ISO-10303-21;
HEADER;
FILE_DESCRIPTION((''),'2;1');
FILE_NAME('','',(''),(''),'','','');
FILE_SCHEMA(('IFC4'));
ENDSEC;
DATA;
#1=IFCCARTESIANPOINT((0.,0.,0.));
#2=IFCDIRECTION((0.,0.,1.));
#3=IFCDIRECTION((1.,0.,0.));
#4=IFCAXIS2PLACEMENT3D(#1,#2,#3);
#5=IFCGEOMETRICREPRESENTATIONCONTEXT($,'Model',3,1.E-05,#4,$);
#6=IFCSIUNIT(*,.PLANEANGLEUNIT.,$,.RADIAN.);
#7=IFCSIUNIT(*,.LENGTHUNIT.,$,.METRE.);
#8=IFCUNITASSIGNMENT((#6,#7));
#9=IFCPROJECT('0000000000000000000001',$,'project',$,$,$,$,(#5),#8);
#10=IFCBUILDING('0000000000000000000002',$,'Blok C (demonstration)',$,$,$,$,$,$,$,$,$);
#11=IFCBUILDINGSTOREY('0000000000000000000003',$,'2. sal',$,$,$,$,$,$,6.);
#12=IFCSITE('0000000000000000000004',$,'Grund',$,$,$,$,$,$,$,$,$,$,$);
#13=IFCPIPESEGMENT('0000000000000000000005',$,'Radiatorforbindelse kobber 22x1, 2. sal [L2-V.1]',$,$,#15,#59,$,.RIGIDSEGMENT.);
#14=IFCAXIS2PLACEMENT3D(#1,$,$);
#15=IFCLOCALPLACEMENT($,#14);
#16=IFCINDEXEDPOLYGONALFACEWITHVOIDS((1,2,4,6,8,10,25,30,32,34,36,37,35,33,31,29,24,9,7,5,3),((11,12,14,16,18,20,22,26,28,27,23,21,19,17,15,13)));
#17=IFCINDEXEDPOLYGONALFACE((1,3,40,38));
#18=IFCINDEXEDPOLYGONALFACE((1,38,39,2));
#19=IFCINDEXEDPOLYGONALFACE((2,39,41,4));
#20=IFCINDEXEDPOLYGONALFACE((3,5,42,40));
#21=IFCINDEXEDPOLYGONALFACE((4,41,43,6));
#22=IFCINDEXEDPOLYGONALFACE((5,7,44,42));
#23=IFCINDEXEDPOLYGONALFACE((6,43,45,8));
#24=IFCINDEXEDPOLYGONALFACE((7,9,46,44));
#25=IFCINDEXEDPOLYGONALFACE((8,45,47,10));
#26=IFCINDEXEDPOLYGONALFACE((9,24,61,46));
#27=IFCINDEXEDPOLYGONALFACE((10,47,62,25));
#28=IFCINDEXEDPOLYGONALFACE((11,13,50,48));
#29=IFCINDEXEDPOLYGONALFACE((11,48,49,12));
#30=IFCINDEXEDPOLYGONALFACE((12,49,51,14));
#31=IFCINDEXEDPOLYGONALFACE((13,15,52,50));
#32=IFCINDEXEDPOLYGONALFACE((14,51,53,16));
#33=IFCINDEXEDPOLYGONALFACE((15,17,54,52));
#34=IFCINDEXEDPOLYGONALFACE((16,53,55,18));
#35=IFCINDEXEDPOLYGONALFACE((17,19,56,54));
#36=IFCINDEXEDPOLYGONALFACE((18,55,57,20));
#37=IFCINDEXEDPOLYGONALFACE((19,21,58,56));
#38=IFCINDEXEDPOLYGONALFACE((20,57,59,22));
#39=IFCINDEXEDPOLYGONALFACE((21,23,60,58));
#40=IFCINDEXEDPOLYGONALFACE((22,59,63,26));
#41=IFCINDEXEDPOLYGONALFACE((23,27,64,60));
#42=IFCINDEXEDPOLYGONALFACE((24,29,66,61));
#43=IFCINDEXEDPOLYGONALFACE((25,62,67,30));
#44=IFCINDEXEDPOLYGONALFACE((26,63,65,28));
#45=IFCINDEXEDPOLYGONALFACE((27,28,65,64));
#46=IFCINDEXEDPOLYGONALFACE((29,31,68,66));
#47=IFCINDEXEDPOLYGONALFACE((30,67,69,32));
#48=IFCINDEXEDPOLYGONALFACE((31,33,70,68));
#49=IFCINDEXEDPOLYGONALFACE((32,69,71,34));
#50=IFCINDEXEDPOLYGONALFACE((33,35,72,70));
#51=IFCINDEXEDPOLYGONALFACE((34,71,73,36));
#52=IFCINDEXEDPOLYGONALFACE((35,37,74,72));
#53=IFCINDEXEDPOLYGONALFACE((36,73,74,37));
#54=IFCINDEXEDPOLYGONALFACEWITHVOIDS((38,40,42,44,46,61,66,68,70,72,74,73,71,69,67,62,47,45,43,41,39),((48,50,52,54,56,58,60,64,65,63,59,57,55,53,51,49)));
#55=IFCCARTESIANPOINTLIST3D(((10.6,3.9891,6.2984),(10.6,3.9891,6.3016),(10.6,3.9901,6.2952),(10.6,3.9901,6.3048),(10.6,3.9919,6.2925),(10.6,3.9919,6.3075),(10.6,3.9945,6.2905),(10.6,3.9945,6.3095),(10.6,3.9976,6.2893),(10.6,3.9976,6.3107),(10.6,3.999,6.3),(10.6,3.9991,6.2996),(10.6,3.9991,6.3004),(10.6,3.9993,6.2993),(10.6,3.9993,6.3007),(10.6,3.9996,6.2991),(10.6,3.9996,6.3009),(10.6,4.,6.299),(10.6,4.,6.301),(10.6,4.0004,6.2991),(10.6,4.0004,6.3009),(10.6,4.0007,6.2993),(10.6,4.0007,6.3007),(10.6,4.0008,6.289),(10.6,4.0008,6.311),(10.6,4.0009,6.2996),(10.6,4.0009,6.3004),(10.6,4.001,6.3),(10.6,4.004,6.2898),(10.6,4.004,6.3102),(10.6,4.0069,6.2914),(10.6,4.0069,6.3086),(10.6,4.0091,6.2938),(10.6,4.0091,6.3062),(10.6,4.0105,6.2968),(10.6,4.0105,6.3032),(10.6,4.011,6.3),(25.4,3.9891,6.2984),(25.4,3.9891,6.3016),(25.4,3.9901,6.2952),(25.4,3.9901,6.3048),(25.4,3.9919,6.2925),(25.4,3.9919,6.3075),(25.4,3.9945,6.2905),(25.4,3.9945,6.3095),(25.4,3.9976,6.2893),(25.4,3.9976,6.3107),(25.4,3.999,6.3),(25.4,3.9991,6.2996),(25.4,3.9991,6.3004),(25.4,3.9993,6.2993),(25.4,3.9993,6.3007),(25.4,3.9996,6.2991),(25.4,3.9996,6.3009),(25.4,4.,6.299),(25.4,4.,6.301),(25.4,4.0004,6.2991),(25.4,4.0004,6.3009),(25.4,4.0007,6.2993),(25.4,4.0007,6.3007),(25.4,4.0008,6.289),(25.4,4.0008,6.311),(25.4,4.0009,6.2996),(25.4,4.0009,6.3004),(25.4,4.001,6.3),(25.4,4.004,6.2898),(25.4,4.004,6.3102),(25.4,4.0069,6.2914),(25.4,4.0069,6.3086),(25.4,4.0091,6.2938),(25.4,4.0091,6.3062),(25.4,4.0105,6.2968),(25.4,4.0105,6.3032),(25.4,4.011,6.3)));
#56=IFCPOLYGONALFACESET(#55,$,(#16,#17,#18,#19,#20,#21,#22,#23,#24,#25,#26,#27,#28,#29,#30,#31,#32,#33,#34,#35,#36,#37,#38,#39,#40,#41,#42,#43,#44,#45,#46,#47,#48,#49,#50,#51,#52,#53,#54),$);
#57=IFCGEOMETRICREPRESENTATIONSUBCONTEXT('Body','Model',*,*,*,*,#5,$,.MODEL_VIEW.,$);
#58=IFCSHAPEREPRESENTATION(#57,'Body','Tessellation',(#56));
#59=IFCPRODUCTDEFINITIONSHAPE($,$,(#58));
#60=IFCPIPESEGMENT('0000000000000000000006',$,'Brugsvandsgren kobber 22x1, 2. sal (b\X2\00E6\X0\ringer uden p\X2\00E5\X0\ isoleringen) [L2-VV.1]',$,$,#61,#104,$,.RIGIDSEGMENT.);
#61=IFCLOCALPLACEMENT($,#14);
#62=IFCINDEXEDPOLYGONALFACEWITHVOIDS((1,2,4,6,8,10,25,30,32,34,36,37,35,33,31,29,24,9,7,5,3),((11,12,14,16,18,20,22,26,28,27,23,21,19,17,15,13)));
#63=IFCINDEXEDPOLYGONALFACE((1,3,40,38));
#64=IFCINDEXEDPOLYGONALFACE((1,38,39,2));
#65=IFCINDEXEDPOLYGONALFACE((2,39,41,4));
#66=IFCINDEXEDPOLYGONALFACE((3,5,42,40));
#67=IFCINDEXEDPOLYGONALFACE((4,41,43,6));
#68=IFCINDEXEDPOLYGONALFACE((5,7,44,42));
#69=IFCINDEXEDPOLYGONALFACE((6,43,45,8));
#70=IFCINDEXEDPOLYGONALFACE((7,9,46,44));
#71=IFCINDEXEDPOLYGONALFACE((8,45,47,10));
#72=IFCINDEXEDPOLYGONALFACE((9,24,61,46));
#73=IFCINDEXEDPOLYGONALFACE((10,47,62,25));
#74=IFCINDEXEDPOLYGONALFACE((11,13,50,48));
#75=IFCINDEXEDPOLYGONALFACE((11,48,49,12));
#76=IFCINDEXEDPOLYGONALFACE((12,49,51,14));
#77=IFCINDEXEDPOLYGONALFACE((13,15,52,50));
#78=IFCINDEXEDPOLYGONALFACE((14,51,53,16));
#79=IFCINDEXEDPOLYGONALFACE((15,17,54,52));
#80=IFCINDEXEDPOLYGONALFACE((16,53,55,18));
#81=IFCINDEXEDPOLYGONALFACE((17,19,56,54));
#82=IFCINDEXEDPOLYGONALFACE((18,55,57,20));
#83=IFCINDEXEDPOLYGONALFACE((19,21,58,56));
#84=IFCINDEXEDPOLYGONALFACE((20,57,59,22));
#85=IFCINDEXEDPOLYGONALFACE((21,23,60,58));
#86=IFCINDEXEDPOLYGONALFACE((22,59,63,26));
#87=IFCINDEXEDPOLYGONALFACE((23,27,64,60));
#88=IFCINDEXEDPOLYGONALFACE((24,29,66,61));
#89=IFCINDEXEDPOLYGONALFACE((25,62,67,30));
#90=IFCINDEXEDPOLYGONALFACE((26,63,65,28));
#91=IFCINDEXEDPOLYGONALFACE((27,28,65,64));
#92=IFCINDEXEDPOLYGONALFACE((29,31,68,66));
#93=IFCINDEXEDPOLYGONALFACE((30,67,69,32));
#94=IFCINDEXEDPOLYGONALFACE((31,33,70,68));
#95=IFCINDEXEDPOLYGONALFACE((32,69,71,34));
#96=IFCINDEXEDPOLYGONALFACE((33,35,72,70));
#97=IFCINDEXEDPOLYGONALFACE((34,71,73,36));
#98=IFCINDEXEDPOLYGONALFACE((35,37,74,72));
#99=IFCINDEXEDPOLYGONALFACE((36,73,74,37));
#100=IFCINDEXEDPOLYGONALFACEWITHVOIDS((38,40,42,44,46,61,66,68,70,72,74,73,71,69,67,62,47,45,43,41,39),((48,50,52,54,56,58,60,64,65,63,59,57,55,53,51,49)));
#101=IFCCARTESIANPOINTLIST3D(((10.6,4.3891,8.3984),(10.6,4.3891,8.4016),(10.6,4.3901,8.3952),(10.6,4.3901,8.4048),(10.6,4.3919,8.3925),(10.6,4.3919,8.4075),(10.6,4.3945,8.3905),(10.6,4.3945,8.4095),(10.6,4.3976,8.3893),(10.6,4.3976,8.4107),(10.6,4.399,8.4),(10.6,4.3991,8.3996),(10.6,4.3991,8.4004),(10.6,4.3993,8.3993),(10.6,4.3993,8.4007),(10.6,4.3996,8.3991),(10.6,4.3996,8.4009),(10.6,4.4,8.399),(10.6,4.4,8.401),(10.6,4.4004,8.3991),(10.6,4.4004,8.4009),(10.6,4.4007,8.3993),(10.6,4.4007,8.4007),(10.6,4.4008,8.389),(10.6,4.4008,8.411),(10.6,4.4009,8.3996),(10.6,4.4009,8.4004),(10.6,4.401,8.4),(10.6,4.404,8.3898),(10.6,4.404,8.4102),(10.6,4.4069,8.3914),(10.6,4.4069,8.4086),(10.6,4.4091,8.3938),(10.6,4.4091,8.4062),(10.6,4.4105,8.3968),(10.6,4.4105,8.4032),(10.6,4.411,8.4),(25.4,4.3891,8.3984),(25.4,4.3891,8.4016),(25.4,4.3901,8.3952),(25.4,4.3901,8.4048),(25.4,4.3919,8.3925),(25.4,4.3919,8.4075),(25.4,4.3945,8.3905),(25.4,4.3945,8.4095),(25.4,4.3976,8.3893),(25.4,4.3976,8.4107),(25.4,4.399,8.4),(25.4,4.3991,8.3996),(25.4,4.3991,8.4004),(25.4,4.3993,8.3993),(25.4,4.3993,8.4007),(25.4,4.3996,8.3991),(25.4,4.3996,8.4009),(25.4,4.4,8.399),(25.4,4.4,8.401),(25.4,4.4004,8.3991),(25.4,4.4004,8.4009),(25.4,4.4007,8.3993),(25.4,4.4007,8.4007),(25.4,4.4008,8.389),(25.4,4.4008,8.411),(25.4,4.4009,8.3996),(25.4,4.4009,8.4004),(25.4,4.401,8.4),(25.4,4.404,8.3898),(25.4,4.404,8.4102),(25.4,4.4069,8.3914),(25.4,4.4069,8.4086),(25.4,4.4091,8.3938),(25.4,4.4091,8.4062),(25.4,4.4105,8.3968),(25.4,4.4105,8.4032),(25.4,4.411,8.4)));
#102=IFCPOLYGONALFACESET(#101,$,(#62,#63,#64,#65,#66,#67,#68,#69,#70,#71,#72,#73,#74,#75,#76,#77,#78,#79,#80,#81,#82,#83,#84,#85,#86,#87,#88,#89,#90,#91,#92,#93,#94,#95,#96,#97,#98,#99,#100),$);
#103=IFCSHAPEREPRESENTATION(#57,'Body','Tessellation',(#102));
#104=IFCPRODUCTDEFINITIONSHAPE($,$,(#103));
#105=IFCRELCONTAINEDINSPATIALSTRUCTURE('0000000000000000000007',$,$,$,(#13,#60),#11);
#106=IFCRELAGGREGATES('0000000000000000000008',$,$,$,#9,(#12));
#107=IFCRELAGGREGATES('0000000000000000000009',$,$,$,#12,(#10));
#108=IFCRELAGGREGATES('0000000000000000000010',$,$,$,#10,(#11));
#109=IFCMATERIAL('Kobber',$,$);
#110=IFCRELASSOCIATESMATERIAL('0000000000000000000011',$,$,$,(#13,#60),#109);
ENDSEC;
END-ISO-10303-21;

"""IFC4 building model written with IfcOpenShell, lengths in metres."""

from ifc_helpers import new_model, si_unit, frame, origin_with_axes, place, context, subcontext, project, spatial, hollow_circle, extrude, material, element, save


model = new_model("IFC4")

# Units and contexts
model_context = context("Model", 3, precision=1e-05, world=origin_with_axes())
body_context = subcontext(model_context, "Body", "Model", "MODEL_VIEW")
ifc_project = project(units=[si_unit("PLANEANGLEUNIT", "RADIAN"), si_unit("LENGTHUNIT", "METRE")], contexts=[model_context])

# Site, building, storey
site = spatial("IfcSite", under=ifc_project, Name="Grund")
building = spatial("IfcBuilding", under=site, Name="Blok C (demonstration)")
storey = spatial("IfcBuildingStorey", under=building, Name="2. sal", Elevation=6.0)

# Pipe segments
ifc_material_1 = material(Name="Kobber")
pipe_segment_1_placement = place(None, origin_with_axes())
element("IfcPipeSegment", 1, at=pipe_segment_1_placement, inside=storey, material=ifc_material_1, Name="Radiatorforbindelse kobber 22x1, 2. sal [L2-V.1]", PredefinedType="RIGIDSEGMENT", context=body_context, shape_type="SweptSolid", body=[
    extrude(hollow_circle(Radius=0.011, WallThickness=0.01), frame((10.6, 4.0, 6.3), z_axis=(1.0, 0.0, 0.0), x_axis=(0.0, 1.0, 0.0)), (0.0, 0.0, 1.0), 14.8),
])
pipe_segment_2_placement = place(None, origin_with_axes())
element("IfcPipeSegment", 2, at=pipe_segment_2_placement, inside=storey, material=ifc_material_1, Name="Brugsvandsgren kobber 22x1, 2. sal (bæringer uden på isoleringen) [L2-VV.1]", PredefinedType="RIGIDSEGMENT", context=body_context, shape_type="SweptSolid", body=[
    extrude(hollow_circle(Radius=0.011, WallThickness=0.01), frame((10.6, 4.4, 8.4), z_axis=(1.0, 0.0, 0.0), x_axis=(0.0, 1.0, 0.0)), (0.0, 0.0, 1.0), 14.8),
])

save(model, "model.ifc")
